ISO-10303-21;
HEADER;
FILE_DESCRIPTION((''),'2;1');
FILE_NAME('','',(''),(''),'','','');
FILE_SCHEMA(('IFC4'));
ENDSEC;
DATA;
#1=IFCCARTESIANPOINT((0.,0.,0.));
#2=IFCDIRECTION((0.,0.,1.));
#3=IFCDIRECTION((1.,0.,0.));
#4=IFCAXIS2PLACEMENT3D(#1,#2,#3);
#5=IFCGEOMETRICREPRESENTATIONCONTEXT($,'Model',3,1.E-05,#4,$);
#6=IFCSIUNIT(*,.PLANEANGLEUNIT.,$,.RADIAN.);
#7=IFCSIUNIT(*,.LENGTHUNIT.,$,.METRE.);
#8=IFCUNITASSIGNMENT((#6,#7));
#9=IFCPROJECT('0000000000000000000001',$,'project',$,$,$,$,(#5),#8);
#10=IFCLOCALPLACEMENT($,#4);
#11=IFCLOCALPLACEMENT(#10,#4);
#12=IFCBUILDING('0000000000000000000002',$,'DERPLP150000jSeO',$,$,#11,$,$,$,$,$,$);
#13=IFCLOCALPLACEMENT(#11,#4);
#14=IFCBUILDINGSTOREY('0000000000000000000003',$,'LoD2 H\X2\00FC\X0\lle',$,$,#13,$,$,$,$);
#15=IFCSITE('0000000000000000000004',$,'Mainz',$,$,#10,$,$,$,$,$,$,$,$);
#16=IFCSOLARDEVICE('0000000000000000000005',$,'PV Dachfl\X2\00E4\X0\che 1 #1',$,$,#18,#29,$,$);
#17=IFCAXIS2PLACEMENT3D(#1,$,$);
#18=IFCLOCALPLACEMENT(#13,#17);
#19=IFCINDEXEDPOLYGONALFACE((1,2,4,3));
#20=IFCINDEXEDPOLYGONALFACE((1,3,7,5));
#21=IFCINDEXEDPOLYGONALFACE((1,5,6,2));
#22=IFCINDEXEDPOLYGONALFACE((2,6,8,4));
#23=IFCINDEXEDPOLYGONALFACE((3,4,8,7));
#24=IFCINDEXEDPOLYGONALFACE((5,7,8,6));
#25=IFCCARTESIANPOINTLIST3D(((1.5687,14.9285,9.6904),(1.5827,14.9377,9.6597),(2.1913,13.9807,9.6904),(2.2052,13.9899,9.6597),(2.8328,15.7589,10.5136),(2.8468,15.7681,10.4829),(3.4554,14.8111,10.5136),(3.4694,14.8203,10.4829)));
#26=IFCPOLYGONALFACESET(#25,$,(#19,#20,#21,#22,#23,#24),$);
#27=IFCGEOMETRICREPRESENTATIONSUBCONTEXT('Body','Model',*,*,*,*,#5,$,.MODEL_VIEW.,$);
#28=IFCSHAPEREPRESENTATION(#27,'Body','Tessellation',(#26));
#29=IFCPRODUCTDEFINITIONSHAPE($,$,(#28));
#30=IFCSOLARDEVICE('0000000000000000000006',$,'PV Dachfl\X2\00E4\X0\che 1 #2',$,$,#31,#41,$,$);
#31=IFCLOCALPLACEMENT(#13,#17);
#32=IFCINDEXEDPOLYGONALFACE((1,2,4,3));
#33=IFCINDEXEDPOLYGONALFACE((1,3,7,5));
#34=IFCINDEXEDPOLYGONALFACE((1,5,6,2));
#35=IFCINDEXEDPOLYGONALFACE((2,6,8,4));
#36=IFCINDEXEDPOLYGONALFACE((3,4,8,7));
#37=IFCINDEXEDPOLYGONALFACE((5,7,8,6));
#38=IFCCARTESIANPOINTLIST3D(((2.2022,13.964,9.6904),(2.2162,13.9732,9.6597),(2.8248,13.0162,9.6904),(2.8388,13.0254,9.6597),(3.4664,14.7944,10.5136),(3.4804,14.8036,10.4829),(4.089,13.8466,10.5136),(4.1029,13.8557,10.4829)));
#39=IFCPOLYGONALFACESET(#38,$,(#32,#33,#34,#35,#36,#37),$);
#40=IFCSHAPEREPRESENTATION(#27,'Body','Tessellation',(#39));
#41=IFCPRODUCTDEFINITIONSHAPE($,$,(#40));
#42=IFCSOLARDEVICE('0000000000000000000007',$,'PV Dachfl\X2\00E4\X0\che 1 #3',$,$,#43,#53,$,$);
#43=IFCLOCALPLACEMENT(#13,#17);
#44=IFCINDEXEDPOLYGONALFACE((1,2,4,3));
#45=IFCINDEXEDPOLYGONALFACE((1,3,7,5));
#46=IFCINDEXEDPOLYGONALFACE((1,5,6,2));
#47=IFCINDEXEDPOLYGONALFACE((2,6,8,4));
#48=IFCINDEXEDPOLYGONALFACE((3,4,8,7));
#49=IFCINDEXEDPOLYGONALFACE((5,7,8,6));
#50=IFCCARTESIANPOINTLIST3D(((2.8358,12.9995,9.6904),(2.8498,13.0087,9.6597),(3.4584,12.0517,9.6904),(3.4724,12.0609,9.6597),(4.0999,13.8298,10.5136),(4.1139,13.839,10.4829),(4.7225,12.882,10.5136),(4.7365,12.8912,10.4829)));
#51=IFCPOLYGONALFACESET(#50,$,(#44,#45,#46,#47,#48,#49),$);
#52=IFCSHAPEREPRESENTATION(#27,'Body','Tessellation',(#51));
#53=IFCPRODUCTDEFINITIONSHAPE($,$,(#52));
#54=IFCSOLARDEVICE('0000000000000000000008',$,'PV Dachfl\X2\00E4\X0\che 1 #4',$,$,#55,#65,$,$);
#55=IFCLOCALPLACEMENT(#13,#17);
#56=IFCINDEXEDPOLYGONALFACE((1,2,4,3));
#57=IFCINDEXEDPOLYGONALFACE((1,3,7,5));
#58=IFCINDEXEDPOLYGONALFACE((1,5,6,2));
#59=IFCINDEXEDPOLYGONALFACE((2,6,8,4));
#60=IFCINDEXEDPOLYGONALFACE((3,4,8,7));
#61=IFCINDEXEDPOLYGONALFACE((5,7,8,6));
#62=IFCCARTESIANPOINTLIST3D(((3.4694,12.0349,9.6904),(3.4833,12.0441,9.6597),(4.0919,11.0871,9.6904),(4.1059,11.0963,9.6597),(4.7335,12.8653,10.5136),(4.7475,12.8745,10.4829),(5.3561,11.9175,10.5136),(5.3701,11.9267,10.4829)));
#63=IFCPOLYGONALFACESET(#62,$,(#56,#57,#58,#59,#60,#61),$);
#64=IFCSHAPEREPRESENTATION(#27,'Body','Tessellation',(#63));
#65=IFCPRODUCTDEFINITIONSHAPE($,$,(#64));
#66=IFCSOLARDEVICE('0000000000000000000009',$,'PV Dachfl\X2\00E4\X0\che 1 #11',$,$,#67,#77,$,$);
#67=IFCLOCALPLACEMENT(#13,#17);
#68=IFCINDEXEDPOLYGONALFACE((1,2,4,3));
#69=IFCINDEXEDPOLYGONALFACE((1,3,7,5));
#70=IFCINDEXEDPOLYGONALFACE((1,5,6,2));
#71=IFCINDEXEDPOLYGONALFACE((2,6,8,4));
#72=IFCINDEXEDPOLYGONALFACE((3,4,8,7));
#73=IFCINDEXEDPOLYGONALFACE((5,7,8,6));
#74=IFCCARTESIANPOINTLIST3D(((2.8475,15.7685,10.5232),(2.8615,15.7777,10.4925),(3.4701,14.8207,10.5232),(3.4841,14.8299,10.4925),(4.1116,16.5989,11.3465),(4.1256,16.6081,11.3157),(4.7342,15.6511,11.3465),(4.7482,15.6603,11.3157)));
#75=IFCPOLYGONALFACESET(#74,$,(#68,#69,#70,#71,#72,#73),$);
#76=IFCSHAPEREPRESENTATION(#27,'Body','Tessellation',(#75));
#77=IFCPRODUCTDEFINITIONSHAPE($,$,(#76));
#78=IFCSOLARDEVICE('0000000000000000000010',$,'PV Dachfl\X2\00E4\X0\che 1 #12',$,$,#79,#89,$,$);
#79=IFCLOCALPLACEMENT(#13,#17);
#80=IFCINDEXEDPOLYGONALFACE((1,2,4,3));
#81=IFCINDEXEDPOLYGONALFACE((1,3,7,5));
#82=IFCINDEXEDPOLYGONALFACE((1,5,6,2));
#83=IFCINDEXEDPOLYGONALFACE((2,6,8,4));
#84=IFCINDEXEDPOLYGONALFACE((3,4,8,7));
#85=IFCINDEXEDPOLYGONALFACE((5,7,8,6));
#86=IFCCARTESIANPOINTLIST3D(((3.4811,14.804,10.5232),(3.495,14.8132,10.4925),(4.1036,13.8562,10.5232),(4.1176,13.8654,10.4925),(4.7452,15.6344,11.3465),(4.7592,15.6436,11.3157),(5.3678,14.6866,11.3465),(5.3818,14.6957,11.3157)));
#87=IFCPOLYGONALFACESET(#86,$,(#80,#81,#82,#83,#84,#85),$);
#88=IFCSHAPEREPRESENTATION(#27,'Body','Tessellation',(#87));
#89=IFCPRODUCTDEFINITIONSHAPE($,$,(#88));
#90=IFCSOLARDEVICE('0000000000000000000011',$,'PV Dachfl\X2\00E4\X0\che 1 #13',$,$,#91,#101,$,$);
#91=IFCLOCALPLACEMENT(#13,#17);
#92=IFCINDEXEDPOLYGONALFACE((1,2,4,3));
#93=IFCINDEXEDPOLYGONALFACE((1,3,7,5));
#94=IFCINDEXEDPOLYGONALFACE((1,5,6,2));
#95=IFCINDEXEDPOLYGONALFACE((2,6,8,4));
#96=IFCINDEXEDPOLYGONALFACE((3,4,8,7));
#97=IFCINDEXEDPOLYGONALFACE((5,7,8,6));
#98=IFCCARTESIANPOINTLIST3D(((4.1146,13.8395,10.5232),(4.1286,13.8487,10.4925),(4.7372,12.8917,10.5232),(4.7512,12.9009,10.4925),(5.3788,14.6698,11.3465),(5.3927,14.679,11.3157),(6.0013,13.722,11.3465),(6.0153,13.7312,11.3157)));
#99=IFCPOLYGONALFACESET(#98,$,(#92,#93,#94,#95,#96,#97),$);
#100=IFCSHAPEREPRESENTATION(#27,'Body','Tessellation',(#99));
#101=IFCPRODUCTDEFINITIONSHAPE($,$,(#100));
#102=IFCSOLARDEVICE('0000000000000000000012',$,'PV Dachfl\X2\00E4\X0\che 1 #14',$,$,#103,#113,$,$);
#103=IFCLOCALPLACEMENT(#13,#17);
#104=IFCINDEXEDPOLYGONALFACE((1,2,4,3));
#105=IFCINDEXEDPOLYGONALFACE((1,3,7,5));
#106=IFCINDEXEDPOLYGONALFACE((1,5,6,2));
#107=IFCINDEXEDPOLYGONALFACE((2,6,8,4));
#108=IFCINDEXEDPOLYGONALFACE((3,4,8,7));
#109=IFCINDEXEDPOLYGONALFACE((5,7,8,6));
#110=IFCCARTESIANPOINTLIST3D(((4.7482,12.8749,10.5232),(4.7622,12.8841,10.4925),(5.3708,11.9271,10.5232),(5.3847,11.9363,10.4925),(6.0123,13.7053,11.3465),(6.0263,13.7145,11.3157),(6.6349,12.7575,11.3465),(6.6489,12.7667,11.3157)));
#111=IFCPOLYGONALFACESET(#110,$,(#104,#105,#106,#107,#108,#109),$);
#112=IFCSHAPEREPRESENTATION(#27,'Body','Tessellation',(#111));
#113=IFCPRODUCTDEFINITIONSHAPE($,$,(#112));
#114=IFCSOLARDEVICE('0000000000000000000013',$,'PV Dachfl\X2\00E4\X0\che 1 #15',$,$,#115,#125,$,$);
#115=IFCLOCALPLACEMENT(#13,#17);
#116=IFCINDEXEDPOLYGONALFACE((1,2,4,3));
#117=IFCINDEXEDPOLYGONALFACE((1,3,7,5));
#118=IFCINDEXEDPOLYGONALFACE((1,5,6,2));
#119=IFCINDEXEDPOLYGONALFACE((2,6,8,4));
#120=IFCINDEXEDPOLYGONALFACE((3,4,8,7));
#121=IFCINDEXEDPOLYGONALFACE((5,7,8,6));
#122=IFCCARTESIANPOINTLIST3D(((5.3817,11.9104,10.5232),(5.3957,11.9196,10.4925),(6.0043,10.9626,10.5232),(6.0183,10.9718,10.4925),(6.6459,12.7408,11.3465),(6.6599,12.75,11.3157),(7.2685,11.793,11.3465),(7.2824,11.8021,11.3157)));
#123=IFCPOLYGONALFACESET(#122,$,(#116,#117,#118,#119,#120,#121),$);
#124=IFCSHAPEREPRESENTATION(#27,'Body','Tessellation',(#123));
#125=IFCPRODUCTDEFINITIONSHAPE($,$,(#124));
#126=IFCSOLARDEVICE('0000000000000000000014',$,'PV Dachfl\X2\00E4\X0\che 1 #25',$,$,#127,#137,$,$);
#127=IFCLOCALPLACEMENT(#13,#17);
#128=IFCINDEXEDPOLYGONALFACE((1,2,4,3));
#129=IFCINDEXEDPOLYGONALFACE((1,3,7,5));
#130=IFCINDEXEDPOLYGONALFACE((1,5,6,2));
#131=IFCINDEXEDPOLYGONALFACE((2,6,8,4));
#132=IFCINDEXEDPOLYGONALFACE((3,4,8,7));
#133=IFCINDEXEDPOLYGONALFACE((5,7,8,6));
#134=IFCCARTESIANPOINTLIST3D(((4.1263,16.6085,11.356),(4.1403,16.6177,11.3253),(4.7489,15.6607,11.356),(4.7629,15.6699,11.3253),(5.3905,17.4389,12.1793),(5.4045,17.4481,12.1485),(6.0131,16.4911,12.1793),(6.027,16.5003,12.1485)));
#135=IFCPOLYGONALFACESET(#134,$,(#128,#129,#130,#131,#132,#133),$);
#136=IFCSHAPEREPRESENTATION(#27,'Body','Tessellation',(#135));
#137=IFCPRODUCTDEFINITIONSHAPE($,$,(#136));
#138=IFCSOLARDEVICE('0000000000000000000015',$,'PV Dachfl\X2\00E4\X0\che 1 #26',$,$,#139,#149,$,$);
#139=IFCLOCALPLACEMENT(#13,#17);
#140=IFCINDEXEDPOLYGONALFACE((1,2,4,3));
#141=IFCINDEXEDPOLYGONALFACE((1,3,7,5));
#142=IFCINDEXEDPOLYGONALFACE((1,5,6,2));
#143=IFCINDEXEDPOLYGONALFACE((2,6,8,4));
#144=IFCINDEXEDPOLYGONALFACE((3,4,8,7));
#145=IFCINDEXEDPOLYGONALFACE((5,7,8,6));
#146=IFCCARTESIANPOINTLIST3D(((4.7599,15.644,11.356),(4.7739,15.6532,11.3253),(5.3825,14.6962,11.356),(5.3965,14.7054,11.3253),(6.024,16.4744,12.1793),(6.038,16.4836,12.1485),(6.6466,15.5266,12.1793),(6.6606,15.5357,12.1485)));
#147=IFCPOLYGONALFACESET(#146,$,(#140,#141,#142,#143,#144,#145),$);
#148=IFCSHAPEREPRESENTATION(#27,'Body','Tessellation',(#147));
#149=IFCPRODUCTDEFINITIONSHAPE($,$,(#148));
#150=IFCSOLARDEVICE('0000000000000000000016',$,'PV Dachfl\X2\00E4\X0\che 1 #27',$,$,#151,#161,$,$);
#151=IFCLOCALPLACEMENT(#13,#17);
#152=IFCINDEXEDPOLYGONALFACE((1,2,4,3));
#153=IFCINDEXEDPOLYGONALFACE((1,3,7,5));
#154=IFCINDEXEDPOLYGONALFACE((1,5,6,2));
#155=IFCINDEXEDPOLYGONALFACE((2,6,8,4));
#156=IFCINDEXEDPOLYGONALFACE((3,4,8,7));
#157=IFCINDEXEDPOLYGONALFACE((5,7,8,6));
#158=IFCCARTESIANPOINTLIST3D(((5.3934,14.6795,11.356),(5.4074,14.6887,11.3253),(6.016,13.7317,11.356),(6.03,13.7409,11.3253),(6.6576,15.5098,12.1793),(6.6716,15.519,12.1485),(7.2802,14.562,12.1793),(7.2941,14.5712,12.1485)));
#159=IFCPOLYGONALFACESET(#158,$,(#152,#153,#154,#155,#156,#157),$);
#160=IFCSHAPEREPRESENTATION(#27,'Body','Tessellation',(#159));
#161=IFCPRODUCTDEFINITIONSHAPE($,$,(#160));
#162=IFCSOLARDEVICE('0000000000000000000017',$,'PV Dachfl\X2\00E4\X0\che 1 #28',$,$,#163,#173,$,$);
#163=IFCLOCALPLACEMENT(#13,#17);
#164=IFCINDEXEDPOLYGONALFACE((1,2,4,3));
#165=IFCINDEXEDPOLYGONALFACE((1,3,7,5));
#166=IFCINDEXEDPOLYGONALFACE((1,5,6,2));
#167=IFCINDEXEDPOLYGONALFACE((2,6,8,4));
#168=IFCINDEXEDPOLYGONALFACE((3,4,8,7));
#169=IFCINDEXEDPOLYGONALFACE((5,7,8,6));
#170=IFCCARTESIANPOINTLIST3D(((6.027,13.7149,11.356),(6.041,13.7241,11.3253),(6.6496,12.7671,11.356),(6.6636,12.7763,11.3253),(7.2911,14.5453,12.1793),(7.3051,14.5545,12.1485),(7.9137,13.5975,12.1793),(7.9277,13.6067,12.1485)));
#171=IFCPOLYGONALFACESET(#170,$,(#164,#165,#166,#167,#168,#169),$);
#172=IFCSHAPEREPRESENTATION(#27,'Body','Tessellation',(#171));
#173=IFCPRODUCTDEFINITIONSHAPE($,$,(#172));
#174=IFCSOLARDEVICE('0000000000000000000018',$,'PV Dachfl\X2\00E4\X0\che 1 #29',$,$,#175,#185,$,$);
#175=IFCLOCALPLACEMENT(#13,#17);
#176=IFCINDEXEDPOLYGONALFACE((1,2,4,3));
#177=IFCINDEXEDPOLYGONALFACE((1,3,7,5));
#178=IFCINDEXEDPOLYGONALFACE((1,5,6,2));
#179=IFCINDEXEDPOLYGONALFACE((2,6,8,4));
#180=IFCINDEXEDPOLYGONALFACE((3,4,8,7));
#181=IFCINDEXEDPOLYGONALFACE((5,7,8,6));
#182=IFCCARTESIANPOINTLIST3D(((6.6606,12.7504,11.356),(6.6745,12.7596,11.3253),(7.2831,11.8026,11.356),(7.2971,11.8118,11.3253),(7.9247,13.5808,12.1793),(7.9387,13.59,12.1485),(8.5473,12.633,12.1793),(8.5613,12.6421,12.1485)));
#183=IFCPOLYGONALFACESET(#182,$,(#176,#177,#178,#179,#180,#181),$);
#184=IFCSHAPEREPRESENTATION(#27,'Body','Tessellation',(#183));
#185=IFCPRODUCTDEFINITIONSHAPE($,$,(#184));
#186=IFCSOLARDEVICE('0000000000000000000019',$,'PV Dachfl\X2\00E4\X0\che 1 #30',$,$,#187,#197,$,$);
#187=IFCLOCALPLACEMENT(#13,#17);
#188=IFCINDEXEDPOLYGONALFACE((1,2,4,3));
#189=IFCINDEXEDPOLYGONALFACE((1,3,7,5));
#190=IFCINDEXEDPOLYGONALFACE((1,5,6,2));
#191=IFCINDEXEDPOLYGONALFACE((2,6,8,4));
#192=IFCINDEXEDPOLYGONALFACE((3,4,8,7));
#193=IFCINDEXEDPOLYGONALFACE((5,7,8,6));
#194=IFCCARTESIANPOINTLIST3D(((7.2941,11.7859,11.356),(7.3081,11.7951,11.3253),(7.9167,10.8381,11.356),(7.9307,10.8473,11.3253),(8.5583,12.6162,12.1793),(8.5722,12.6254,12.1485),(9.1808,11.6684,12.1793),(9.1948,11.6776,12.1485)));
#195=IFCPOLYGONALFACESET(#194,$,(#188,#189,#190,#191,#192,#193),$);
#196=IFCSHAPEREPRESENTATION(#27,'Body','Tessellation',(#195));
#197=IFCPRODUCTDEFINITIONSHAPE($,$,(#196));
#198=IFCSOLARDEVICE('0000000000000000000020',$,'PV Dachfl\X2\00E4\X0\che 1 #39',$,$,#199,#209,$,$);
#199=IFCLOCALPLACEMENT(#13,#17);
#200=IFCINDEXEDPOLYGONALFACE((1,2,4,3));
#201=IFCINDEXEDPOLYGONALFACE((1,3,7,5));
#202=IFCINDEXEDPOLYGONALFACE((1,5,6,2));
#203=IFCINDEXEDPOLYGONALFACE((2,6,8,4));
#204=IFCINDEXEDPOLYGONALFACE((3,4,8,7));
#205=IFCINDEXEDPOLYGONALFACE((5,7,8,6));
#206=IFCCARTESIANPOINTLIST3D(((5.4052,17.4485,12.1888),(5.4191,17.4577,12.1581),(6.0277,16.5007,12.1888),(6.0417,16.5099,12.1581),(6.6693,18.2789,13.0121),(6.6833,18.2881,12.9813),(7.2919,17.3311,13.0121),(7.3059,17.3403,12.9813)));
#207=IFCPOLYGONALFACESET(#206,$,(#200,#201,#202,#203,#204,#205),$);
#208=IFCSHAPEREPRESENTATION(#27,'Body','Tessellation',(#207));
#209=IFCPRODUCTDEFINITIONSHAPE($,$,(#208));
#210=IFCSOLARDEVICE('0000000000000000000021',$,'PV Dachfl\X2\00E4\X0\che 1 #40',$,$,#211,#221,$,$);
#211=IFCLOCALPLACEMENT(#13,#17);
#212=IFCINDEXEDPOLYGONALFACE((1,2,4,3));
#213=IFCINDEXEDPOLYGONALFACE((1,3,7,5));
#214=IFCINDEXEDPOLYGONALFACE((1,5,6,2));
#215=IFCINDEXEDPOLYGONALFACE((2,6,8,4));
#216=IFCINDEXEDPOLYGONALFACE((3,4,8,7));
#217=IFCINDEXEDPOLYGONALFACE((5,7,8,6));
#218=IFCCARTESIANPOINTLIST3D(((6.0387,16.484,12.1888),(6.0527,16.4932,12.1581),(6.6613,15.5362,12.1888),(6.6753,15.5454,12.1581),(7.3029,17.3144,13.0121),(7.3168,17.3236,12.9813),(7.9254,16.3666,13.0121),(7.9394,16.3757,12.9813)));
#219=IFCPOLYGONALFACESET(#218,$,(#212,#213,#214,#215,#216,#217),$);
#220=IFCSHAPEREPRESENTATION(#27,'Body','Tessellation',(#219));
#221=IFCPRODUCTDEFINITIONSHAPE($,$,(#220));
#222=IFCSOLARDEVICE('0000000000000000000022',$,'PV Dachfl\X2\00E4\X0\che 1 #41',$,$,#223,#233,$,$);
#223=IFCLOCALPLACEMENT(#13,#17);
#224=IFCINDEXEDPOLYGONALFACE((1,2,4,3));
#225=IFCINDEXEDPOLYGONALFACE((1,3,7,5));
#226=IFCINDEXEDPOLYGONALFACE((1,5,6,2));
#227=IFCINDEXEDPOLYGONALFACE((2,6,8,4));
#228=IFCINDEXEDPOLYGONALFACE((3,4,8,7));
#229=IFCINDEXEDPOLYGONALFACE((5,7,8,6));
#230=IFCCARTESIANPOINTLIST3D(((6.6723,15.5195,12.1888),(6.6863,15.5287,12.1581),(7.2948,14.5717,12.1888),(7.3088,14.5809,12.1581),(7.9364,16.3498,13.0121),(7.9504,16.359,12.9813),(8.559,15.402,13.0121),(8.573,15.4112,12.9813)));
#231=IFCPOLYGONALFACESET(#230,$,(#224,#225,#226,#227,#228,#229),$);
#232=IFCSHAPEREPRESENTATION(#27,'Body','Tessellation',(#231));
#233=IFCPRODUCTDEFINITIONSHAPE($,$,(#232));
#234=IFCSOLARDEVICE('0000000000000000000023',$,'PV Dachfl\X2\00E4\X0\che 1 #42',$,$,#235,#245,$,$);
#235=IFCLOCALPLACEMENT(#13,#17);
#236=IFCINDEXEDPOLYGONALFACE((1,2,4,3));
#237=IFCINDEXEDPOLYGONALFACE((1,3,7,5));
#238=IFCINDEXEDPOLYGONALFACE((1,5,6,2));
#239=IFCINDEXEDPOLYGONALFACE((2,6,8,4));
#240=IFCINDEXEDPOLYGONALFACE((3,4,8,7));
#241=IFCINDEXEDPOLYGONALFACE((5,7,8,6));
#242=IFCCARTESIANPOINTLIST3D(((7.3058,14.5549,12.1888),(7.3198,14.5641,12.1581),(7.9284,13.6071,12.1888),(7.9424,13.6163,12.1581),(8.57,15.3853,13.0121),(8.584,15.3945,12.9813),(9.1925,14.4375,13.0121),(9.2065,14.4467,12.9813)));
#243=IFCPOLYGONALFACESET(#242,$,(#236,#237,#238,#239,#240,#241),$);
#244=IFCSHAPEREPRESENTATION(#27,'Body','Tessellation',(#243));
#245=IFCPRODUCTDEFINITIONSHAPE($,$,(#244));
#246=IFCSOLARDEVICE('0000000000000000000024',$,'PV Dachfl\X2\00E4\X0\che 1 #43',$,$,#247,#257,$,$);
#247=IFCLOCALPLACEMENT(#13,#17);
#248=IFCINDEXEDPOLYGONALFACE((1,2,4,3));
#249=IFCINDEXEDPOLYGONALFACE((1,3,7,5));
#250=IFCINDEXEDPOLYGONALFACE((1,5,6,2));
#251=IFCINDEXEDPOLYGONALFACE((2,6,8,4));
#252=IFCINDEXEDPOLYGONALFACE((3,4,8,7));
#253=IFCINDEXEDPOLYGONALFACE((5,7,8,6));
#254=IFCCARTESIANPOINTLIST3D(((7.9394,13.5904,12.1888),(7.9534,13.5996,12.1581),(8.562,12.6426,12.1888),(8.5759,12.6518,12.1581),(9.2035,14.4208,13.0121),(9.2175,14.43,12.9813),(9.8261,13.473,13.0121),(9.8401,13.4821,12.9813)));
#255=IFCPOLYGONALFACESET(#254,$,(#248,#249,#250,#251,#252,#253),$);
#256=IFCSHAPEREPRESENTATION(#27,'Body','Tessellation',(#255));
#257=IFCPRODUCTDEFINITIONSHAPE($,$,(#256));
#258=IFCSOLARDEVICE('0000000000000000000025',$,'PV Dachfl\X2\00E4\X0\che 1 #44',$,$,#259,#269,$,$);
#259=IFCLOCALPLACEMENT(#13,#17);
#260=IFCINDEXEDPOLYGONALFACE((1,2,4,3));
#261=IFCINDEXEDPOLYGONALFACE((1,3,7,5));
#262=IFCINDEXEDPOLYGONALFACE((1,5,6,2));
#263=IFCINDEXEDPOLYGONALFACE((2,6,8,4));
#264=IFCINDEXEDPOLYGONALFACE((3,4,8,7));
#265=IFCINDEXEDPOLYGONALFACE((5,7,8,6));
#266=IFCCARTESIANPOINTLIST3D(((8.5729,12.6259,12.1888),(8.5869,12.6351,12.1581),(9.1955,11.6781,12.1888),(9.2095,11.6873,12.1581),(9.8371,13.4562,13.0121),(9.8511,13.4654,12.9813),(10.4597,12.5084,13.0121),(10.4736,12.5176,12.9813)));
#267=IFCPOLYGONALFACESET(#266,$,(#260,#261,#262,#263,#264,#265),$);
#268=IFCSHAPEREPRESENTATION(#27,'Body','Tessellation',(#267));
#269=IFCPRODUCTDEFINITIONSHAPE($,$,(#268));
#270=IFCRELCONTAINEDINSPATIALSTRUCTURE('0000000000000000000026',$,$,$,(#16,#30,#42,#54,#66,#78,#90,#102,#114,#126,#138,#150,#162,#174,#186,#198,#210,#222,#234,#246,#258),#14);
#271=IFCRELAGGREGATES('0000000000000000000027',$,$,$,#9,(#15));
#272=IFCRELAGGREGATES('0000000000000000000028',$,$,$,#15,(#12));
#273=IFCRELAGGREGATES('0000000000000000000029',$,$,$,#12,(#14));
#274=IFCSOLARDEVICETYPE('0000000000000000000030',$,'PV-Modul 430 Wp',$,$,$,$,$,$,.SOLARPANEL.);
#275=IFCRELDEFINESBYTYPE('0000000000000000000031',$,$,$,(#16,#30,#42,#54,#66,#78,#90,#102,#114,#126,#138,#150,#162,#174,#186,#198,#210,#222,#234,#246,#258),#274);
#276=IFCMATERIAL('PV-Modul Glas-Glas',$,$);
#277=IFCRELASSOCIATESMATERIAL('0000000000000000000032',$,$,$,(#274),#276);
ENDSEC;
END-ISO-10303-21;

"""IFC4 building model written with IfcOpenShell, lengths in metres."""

from ifc_helpers import new_model, si_unit, frame, frame_2d, origin, origin_with_axes, place, context, subcontext, project, spatial, rectangle, extrude, source, transform, mapped, material, type_object, type_shapes, element, save


model = new_model("IFC4")

# Units and contexts
model_context = context("Model", 3, precision=1e-05, world=origin_with_axes())
body_context = subcontext(model_context, "Body", "Model", "MODEL_VIEW")
ifc_project = project(units=[si_unit("PLANEANGLEUNIT", "RADIAN"), si_unit("LENGTHUNIT", "METRE")], contexts=[model_context])

# Site, building, storey
site_placement = place(None, origin_with_axes())
site = spatial("IfcSite", under=ifc_project, at=site_placement, Name="Mainz")
building_placement = place(site_placement, origin_with_axes())
building = spatial("IfcBuilding", under=site, at=building_placement, Name="DERPLP150000jSeO")
storey_placement = place(building_placement, origin_with_axes())
storey = spatial("IfcBuildingStorey", under=building, at=storey_placement, Name="LoD2 Hülle")

# Solar devices
ifc_material = material(Name="PV-Modul Glas-Glas")
solar_device_type = type_object("IfcSolarDeviceType", Name="PV-Modul 430 Wp", PredefinedType="SOLARPANEL", material=ifc_material)
shared_shape = source(origin_with_axes(), body_context, "Body", "SweptSolid", [
    extrude(rectangle(XDim=1.722, YDim=1.134, at=frame_2d((0.861, 0.567))), origin(), (0.0, 0.0, 1.0), 0.035),
])
type_shapes(solar_device_type, [shared_shape])
for number, where, z_axis, x_axis, name in (
    (1, (2.2052, 13.9899, 9.6597), (-0.399585, -0.262469, 0.878318), (0.734113, 0.482204, 0.478077), "PV Dachfläche 1 #1"),
    (2, (2.8388, 13.0254, 9.6597), (-0.399585, -0.262469, 0.878318), (0.734113, 0.482204, 0.478077), "PV Dachfläche 1 #2"),
    (3, (3.4724, 12.0609, 9.6597), (-0.399585, -0.262469, 0.878318), (0.734113, 0.482204, 0.478077), "PV Dachfläche 1 #3"),
    (4, (4.1059, 11.0963, 9.6597), (-0.399585, -0.262469, 0.878318), (0.734113, 0.482204, 0.478077), "PV Dachfläche 1 #4"),
    (5, (3.4841, 14.8299, 10.4925), (-0.399585, -0.262469, 0.878318), (0.734113, 0.482204, 0.478077), "PV Dachfläche 1 #11"),
    (6, (4.1176, 13.8654, 10.4925), (-0.399585, -0.262469, 0.878318), (0.734113, 0.482204, 0.478077), "PV Dachfläche 1 #12"),
    (7, (4.7512, 12.9009, 10.4925), (-0.399585, -0.262469, 0.878318), (0.734113, 0.482204, 0.478077), "PV Dachfläche 1 #13"),
    (8, (5.3847, 11.9363, 10.4925), (-0.399585, -0.262469, 0.878318), (0.734113, 0.482204, 0.478077), "PV Dachfläche 1 #14"),
    (9, (6.0183, 10.9718, 10.4925), (-0.399585, -0.262469, 0.878318), (0.734113, 0.482204, 0.478077), "PV Dachfläche 1 #15"),
    (10, (4.7629, 15.6699, 11.3253), (-0.399585, -0.262469, 0.878318), (0.734113, 0.482204, 0.478077), "PV Dachfläche 1 #25"),
    (11, (5.3965, 14.7054, 11.3253), (-0.399585, -0.262469, 0.878318), (0.734113, 0.482204, 0.478077), "PV Dachfläche 1 #26"),
    (12, (6.03, 13.7409, 11.3253), (-0.399585, -0.262469, 0.878318), (0.734113, 0.482204, 0.478077), "PV Dachfläche 1 #27"),
    (13, (6.6636, 12.7763, 11.3253), (-0.399585, -0.262469, 0.878318), (0.734113, 0.482204, 0.478077), "PV Dachfläche 1 #28"),
    (14, (7.2971, 11.8118, 11.3253), (-0.399585, -0.262469, 0.878318), (0.734113, 0.482204, 0.478077), "PV Dachfläche 1 #29"),
    (15, (7.9307, 10.8473, 11.3253), (-0.399585, -0.262469, 0.878318), (0.734113, 0.482204, 0.478077), "PV Dachfläche 1 #30"),
    (16, (6.0417, 16.5099, 12.1581), (-0.399585, -0.262469, 0.878318), (0.734113, 0.482204, 0.478077), "PV Dachfläche 1 #39"),
    (17, (6.6753, 15.5454, 12.1581), (-0.399585, -0.262469, 0.878318), (0.734113, 0.482204, 0.478077), "PV Dachfläche 1 #40"),
    (18, (7.3088, 14.5809, 12.1581), (-0.399585, -0.262469, 0.878318), (0.734113, 0.482204, 0.478077), "PV Dachfläche 1 #41"),
    (19, (7.9424, 13.6163, 12.1581), (-0.399585, -0.262469, 0.878318), (0.734113, 0.482204, 0.478077), "PV Dachfläche 1 #42"),
    (20, (8.5759, 12.6518, 12.1581), (-0.399585, -0.262469, 0.878318), (0.734113, 0.482204, 0.478077), "PV Dachfläche 1 #43"),
    (21, (9.2095, 11.6873, 12.1581), (-0.399585, -0.262469, 0.878318), (0.734113, 0.482204, 0.478077), "PV Dachfläche 1 #44"),
):
    element("IfcSolarDevice", number, at=place(storey_placement, frame(where, z_axis=z_axis, x_axis=x_axis)), inside=storey, type_object=solar_device_type, Name=name, context=body_context, shape_type="MappedRepresentation", body=[
        mapped(shared_shape, transform((0.0, 0.0, 0.0), x_axis=(1.0, 0.0, 0.0), y_axis=(0.0, 1.0, 0.0), z_axis=(0.0, 0.0, 1.0), scale=1.0)),
    ])

save(model, "model.ifc")
